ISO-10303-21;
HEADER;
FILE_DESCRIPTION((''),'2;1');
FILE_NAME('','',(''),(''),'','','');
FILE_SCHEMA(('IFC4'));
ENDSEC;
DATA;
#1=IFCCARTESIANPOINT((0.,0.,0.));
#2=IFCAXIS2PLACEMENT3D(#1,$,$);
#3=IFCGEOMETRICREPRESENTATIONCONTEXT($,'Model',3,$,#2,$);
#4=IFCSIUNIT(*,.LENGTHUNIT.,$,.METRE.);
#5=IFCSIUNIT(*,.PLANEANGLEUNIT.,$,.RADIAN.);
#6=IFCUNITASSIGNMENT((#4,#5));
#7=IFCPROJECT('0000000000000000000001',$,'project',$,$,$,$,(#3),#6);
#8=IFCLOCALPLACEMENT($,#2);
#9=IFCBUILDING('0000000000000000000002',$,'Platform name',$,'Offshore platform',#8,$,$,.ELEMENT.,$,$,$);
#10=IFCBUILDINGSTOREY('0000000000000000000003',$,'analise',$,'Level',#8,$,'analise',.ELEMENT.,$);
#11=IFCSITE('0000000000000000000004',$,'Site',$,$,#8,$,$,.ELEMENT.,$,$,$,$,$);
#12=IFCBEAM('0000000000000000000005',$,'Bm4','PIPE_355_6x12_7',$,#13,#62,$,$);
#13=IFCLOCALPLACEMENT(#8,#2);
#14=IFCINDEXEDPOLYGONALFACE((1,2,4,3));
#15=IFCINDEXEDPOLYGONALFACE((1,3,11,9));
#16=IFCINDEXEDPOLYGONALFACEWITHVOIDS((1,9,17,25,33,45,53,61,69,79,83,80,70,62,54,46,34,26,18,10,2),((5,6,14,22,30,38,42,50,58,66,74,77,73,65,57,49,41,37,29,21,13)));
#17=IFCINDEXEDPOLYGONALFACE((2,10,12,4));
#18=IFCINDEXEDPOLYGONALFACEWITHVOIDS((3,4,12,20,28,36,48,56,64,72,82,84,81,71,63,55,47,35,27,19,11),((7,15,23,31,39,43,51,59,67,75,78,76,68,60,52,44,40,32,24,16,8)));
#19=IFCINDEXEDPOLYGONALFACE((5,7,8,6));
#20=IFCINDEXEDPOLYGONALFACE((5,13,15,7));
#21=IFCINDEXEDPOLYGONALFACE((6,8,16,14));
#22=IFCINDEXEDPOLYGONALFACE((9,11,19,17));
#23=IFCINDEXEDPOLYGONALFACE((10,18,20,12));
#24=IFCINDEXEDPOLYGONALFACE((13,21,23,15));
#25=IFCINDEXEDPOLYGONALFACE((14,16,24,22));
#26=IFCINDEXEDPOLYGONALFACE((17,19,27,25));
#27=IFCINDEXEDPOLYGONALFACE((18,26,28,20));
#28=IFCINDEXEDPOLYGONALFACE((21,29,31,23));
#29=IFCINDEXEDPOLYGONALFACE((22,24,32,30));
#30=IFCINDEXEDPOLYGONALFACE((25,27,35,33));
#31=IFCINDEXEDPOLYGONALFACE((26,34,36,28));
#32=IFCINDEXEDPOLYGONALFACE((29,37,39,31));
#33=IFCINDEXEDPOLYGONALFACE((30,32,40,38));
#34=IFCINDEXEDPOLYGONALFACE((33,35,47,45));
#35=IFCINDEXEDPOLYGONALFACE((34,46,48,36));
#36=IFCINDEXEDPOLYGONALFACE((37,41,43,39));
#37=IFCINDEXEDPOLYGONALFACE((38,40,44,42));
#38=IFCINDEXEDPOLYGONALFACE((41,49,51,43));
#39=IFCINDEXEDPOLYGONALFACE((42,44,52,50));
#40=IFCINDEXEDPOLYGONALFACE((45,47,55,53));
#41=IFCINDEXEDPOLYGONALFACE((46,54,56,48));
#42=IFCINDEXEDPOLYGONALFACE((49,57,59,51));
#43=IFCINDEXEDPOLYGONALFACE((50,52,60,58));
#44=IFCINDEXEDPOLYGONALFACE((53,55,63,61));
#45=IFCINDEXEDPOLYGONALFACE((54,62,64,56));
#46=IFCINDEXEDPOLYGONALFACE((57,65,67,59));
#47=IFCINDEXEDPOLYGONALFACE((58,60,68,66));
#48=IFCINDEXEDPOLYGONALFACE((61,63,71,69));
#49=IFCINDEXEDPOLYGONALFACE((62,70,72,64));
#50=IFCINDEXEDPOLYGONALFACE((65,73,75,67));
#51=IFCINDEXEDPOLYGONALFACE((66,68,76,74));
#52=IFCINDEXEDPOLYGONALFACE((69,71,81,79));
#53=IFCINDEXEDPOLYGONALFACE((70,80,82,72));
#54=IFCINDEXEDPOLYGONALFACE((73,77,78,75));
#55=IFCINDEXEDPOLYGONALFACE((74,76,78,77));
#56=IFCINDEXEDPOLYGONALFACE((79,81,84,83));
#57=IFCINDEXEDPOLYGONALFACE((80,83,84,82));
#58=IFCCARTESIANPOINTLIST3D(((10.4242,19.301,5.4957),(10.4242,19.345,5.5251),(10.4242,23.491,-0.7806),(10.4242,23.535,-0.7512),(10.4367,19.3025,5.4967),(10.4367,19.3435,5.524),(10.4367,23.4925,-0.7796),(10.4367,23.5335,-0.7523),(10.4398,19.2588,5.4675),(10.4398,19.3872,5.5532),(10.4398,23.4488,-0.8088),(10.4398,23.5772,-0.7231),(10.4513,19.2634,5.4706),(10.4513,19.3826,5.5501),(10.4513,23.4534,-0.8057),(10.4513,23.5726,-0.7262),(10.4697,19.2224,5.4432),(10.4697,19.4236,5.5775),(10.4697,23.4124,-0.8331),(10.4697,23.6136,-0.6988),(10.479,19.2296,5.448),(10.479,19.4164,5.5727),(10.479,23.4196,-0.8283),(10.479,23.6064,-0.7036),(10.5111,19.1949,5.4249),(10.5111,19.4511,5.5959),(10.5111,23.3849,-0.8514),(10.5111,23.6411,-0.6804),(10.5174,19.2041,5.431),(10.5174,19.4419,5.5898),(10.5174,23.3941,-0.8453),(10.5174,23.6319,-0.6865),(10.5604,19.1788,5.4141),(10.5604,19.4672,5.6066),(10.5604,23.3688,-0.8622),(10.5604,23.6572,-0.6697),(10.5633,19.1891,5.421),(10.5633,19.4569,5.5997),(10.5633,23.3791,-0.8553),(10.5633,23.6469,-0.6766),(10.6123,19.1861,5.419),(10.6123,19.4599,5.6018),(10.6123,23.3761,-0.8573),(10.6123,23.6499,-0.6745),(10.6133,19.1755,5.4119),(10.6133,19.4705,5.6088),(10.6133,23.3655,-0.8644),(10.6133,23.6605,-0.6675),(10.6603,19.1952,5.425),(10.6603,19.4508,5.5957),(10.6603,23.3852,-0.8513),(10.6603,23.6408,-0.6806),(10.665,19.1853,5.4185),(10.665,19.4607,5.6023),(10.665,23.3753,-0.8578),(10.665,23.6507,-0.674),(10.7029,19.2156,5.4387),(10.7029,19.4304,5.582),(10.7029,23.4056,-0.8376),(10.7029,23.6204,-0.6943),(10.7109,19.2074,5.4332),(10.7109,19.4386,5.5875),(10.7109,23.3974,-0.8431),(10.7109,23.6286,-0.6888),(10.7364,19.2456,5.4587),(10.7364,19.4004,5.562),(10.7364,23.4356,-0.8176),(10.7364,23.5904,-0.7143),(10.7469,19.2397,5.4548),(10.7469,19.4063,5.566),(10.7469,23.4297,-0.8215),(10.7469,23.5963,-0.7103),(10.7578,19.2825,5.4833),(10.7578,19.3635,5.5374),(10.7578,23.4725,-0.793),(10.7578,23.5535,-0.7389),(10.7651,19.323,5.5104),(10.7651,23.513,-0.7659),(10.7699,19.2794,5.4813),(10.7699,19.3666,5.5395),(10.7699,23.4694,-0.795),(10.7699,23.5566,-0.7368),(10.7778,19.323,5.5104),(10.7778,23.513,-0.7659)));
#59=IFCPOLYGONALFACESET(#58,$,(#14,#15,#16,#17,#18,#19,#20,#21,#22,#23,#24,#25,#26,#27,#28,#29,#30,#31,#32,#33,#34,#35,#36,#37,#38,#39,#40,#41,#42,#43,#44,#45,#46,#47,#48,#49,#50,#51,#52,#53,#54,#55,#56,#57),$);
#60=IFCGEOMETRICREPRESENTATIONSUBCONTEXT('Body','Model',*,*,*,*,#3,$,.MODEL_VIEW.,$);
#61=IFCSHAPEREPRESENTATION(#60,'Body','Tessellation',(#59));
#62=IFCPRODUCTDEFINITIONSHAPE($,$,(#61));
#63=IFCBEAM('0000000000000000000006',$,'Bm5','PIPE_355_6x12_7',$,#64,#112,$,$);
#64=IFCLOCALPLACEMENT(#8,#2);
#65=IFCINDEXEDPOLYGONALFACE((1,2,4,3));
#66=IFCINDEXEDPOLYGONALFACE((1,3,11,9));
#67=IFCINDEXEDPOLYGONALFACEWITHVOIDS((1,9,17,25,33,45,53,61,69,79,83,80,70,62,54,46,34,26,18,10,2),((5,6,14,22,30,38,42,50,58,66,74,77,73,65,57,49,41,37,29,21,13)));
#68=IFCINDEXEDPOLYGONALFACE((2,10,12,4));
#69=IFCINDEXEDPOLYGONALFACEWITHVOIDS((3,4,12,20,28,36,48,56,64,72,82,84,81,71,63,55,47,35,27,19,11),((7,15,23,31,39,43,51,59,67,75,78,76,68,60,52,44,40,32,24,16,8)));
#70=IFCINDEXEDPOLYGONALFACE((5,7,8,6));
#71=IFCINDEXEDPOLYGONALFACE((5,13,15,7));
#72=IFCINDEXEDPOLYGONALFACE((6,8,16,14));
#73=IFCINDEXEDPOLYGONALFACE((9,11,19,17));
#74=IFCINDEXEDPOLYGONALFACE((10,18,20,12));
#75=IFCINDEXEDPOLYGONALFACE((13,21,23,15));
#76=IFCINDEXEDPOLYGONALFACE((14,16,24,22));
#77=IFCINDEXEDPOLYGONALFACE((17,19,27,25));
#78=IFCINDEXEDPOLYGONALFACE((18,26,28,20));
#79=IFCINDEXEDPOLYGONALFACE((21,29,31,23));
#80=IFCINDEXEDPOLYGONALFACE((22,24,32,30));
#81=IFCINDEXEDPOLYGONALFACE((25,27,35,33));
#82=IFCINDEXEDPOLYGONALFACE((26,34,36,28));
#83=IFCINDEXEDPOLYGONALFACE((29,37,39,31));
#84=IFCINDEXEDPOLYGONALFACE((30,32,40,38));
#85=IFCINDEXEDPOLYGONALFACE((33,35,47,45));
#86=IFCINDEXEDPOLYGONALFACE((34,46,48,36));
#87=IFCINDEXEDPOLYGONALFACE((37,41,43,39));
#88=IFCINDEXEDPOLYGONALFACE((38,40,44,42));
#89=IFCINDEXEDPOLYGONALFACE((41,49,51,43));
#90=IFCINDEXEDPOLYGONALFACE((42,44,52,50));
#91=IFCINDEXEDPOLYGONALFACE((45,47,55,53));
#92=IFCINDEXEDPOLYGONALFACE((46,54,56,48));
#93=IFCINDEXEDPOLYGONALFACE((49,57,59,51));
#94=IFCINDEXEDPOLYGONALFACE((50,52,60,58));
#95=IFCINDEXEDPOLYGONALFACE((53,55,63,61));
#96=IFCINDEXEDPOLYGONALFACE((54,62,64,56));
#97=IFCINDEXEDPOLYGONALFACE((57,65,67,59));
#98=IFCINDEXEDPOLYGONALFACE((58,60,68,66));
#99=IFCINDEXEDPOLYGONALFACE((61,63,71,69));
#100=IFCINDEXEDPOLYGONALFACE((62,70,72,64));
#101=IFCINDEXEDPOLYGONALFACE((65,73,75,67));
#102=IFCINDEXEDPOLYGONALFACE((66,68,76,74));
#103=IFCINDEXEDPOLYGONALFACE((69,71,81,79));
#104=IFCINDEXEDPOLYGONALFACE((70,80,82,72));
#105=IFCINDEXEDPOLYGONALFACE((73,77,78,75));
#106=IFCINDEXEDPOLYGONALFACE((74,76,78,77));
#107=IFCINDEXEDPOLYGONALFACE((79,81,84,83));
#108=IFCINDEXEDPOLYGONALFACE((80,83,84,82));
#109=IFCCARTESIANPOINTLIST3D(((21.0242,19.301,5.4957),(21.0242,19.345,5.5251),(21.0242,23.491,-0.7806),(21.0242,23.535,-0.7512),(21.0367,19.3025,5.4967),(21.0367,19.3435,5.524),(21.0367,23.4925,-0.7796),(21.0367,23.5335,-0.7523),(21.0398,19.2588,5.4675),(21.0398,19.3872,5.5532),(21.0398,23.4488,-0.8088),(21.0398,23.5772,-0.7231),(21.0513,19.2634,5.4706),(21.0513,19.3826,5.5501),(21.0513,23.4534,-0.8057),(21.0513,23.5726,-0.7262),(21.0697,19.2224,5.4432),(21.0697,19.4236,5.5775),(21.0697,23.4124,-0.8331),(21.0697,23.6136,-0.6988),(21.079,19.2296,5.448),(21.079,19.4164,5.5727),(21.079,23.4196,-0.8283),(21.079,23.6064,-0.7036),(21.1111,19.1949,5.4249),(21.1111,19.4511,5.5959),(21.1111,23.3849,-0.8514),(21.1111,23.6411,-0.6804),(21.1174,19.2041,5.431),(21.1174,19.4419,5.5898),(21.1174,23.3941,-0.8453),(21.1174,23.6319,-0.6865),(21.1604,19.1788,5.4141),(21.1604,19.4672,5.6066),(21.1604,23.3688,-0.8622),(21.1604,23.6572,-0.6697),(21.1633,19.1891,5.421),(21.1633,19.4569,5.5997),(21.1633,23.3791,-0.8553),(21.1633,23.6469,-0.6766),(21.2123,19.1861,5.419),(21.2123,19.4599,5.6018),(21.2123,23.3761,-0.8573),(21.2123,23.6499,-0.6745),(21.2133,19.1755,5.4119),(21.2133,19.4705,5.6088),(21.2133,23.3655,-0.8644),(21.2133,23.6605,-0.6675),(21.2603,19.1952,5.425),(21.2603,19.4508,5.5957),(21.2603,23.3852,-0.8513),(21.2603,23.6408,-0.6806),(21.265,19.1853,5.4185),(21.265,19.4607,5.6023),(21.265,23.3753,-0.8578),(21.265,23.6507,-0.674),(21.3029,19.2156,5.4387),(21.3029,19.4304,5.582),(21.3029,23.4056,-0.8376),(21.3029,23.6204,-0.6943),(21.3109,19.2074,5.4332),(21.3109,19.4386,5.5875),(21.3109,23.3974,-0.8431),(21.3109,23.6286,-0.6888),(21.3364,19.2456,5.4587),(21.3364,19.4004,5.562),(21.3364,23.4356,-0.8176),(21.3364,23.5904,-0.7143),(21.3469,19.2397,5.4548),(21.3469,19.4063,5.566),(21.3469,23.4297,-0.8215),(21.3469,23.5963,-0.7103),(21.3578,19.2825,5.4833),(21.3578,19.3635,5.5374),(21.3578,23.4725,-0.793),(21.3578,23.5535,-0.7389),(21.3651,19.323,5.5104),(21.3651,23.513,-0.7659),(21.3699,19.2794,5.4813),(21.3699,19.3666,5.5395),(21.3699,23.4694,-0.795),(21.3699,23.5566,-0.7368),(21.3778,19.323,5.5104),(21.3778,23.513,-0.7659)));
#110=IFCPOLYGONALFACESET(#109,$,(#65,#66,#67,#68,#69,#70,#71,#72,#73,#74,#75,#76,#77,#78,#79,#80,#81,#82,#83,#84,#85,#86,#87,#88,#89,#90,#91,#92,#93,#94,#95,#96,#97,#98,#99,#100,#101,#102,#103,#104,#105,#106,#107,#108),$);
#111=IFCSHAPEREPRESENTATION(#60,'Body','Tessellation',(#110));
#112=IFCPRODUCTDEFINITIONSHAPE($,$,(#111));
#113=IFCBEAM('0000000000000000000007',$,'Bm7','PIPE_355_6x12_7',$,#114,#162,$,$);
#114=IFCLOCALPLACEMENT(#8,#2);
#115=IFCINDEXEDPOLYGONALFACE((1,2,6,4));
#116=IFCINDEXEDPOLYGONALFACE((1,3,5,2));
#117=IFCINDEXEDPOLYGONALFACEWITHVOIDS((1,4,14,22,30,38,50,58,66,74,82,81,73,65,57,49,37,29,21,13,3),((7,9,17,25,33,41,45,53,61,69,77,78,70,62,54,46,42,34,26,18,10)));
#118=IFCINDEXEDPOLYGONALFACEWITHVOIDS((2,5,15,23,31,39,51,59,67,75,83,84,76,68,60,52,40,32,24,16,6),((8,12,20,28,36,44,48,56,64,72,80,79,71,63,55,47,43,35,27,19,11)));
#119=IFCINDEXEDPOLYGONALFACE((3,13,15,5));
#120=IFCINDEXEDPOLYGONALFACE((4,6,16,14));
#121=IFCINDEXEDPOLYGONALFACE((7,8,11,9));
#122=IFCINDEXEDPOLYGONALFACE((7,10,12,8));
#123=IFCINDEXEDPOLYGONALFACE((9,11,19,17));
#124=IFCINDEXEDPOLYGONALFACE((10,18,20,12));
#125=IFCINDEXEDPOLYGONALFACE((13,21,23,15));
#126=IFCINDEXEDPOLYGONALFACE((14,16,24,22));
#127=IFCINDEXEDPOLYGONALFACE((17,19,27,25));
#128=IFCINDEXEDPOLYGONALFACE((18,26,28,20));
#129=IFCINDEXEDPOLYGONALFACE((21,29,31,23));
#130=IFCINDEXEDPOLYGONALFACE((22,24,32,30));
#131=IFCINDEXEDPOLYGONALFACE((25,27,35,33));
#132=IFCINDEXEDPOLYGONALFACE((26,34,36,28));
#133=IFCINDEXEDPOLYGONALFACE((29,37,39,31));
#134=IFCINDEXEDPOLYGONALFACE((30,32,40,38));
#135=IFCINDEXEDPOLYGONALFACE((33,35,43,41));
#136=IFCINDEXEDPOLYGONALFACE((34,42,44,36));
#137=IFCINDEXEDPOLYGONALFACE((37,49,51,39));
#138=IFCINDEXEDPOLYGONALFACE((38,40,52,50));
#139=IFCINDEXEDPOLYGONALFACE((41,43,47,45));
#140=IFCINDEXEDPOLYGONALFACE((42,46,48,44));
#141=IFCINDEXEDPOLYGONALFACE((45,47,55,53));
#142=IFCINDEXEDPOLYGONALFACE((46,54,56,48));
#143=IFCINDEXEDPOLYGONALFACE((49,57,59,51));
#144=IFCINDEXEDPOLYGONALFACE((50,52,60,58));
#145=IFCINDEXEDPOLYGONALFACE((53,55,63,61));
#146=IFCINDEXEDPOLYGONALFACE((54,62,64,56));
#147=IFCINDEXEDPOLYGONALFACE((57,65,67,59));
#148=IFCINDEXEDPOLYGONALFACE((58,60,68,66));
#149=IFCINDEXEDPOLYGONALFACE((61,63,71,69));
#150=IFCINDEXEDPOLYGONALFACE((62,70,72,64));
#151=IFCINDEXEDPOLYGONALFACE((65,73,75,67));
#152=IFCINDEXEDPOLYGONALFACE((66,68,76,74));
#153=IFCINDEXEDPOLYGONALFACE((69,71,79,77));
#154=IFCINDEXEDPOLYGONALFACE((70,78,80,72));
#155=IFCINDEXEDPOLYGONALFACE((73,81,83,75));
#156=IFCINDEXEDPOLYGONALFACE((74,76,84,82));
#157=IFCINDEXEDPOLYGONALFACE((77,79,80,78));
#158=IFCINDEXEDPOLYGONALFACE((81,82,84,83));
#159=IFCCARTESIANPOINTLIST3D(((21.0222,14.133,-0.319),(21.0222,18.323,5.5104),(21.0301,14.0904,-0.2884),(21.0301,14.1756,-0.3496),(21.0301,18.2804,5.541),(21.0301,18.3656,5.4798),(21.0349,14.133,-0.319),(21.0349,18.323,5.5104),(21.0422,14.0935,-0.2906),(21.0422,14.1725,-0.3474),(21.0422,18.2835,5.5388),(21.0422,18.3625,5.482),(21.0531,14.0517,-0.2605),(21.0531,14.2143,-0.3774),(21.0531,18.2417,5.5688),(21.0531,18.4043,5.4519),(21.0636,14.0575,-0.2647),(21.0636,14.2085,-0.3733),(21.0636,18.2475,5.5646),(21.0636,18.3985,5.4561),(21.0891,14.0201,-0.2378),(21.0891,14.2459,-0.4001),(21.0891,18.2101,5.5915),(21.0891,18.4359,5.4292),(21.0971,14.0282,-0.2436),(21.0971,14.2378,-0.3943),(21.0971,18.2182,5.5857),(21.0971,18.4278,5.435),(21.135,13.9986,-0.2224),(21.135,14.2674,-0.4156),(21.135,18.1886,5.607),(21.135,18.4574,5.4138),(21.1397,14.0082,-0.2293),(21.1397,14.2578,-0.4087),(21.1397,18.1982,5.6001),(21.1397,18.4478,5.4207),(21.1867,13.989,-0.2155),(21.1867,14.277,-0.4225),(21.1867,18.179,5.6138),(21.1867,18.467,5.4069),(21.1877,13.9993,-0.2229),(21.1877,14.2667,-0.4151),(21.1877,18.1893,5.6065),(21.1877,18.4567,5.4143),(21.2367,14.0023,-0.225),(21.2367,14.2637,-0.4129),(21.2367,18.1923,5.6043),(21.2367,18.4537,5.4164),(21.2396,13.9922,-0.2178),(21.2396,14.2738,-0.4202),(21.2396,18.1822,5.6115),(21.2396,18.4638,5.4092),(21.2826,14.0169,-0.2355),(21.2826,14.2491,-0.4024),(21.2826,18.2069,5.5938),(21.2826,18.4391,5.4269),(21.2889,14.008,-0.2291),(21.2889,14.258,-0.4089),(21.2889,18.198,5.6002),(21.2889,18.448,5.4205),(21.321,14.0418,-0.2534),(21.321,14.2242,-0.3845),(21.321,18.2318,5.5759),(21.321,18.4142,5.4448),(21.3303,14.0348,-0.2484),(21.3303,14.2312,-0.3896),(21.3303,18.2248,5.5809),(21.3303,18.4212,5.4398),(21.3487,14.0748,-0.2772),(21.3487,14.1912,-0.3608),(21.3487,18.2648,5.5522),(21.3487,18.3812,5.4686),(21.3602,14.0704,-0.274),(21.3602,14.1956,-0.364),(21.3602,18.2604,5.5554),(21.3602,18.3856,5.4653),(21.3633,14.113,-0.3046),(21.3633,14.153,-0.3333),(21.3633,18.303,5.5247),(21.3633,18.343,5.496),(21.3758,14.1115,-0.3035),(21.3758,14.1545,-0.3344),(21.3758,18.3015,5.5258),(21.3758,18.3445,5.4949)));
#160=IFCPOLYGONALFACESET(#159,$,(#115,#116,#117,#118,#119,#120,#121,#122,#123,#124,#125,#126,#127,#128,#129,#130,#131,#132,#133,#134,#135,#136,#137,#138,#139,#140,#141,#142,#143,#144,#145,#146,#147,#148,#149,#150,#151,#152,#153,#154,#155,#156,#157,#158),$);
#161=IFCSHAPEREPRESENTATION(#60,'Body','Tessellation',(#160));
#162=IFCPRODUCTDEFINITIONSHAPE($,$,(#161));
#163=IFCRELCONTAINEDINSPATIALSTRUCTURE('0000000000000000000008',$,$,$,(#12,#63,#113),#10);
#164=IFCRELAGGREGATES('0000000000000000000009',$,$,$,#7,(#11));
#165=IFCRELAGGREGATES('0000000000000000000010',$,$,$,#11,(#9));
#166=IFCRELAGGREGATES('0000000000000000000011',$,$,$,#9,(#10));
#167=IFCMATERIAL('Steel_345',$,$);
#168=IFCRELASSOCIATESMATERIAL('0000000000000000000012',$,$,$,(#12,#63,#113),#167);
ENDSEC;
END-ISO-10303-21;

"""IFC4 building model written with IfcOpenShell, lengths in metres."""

from ifc_helpers import new_model, si_unit, frame, origin, origin_2d, place, context, subcontext, project, spatial, hollow_circle, extrude, source, transform, mapped, material, element, save


model = new_model("IFC4")

# Units and contexts
model_context = context("Model", 3, world=origin())
body_context = subcontext(model_context, "Body", "Model", "MODEL_VIEW")
ifc_project = project(units=[si_unit("LENGTHUNIT", "METRE"), si_unit("PLANEANGLEUNIT", "RADIAN")], contexts=[model_context])

# Site, building, storey
placement_1 = place(None, origin())
site = spatial("IfcSite", under=ifc_project, at=placement_1, Name="Site", CompositionType="ELEMENT")
building = spatial("IfcBuilding", under=site, at=placement_1, Name="Platform name", ObjectType="Offshore platform", CompositionType="ELEMENT")
storey = spatial("IfcBuildingStorey", under=building, at=placement_1, Name="analise", ObjectType="Level", LongName="analise", CompositionType="ELEMENT")

# Beams
ifc_material_1 = material(Name="Steel_345")
shared_shape_1 = source(origin(), body_context, "Body", "SweptSolid", [
    extrude(hollow_circle(Radius=0.1778, WallThickness=0.0127, at=origin_2d()), frame((0.0, 0.0, 0.0), z_axis=(0.0, -0.555232, 0.831695), x_axis=(1.0, 0.0, 0.0)), (0.0, 0.0, 1.0), 7.5464),
])
placement_2 = place(None, origin())
placement_3 = place(placement_2, origin())
placement_4 = place(placement_3, origin())
beam_1_placement = place(placement_4, frame((10.6, 23.513, -0.7659)))
element("IfcBeam", 1, at=beam_1_placement, inside=storey, material=ifc_material_1, Name="Bm4", Description="PIPE_355_6x12_7", context=body_context, shape_type="MappedRepresentation", body=[
    mapped(shared_shape_1, transform((0.0, 0.0, 0.0), scale=1.0)),
])
shared_shape_2 = source(origin(), body_context, "Body", "SweptSolid", [
    extrude(hollow_circle(Radius=0.1778, WallThickness=0.0127, at=origin_2d()), frame((0.0, 0.0, 0.0), z_axis=(0.0, -0.555232, 0.831695), x_axis=(1.0, 0.0, 0.0)), (0.0, 0.0, 1.0), 7.5464),
])
placement_5 = place(None, origin())
placement_6 = place(placement_5, origin())
placement_7 = place(placement_6, origin())
beam_2_placement = place(placement_7, frame((21.2, 23.513, -0.7659)))
element("IfcBeam", 2, at=beam_2_placement, inside=storey, material=ifc_material_1, Name="Bm5", Description="PIPE_355_6x12_7", context=body_context, shape_type="MappedRepresentation", body=[
    mapped(shared_shape_2, transform((0.0, 0.0, 0.0), scale=1.0)),
])
shared_shape_3 = source(origin(), body_context, "Body", "SweptSolid", [
    extrude(hollow_circle(Radius=0.1778, WallThickness=0.0127, at=origin_2d()), frame((0.0, 0.0, 0.0), z_axis=(0.0, 0.583651, 0.812005), x_axis=(-1.0, 0.0, 0.0)), (0.0, 0.0, 1.0), 7.179),
])
placement_8 = place(None, origin())
placement_9 = place(placement_8, origin())
placement_10 = place(placement_9, origin())
beam_3_placement = place(placement_10, frame((21.2, 14.133, -0.319)))
element("IfcBeam", 3, at=beam_3_placement, inside=storey, material=ifc_material_1, Name="Bm7", Description="PIPE_355_6x12_7", context=body_context, shape_type="MappedRepresentation", body=[
    mapped(shared_shape_3, transform((0.0, 0.0, 0.0), scale=1.0)),
])

save(model, "model.ifc")
